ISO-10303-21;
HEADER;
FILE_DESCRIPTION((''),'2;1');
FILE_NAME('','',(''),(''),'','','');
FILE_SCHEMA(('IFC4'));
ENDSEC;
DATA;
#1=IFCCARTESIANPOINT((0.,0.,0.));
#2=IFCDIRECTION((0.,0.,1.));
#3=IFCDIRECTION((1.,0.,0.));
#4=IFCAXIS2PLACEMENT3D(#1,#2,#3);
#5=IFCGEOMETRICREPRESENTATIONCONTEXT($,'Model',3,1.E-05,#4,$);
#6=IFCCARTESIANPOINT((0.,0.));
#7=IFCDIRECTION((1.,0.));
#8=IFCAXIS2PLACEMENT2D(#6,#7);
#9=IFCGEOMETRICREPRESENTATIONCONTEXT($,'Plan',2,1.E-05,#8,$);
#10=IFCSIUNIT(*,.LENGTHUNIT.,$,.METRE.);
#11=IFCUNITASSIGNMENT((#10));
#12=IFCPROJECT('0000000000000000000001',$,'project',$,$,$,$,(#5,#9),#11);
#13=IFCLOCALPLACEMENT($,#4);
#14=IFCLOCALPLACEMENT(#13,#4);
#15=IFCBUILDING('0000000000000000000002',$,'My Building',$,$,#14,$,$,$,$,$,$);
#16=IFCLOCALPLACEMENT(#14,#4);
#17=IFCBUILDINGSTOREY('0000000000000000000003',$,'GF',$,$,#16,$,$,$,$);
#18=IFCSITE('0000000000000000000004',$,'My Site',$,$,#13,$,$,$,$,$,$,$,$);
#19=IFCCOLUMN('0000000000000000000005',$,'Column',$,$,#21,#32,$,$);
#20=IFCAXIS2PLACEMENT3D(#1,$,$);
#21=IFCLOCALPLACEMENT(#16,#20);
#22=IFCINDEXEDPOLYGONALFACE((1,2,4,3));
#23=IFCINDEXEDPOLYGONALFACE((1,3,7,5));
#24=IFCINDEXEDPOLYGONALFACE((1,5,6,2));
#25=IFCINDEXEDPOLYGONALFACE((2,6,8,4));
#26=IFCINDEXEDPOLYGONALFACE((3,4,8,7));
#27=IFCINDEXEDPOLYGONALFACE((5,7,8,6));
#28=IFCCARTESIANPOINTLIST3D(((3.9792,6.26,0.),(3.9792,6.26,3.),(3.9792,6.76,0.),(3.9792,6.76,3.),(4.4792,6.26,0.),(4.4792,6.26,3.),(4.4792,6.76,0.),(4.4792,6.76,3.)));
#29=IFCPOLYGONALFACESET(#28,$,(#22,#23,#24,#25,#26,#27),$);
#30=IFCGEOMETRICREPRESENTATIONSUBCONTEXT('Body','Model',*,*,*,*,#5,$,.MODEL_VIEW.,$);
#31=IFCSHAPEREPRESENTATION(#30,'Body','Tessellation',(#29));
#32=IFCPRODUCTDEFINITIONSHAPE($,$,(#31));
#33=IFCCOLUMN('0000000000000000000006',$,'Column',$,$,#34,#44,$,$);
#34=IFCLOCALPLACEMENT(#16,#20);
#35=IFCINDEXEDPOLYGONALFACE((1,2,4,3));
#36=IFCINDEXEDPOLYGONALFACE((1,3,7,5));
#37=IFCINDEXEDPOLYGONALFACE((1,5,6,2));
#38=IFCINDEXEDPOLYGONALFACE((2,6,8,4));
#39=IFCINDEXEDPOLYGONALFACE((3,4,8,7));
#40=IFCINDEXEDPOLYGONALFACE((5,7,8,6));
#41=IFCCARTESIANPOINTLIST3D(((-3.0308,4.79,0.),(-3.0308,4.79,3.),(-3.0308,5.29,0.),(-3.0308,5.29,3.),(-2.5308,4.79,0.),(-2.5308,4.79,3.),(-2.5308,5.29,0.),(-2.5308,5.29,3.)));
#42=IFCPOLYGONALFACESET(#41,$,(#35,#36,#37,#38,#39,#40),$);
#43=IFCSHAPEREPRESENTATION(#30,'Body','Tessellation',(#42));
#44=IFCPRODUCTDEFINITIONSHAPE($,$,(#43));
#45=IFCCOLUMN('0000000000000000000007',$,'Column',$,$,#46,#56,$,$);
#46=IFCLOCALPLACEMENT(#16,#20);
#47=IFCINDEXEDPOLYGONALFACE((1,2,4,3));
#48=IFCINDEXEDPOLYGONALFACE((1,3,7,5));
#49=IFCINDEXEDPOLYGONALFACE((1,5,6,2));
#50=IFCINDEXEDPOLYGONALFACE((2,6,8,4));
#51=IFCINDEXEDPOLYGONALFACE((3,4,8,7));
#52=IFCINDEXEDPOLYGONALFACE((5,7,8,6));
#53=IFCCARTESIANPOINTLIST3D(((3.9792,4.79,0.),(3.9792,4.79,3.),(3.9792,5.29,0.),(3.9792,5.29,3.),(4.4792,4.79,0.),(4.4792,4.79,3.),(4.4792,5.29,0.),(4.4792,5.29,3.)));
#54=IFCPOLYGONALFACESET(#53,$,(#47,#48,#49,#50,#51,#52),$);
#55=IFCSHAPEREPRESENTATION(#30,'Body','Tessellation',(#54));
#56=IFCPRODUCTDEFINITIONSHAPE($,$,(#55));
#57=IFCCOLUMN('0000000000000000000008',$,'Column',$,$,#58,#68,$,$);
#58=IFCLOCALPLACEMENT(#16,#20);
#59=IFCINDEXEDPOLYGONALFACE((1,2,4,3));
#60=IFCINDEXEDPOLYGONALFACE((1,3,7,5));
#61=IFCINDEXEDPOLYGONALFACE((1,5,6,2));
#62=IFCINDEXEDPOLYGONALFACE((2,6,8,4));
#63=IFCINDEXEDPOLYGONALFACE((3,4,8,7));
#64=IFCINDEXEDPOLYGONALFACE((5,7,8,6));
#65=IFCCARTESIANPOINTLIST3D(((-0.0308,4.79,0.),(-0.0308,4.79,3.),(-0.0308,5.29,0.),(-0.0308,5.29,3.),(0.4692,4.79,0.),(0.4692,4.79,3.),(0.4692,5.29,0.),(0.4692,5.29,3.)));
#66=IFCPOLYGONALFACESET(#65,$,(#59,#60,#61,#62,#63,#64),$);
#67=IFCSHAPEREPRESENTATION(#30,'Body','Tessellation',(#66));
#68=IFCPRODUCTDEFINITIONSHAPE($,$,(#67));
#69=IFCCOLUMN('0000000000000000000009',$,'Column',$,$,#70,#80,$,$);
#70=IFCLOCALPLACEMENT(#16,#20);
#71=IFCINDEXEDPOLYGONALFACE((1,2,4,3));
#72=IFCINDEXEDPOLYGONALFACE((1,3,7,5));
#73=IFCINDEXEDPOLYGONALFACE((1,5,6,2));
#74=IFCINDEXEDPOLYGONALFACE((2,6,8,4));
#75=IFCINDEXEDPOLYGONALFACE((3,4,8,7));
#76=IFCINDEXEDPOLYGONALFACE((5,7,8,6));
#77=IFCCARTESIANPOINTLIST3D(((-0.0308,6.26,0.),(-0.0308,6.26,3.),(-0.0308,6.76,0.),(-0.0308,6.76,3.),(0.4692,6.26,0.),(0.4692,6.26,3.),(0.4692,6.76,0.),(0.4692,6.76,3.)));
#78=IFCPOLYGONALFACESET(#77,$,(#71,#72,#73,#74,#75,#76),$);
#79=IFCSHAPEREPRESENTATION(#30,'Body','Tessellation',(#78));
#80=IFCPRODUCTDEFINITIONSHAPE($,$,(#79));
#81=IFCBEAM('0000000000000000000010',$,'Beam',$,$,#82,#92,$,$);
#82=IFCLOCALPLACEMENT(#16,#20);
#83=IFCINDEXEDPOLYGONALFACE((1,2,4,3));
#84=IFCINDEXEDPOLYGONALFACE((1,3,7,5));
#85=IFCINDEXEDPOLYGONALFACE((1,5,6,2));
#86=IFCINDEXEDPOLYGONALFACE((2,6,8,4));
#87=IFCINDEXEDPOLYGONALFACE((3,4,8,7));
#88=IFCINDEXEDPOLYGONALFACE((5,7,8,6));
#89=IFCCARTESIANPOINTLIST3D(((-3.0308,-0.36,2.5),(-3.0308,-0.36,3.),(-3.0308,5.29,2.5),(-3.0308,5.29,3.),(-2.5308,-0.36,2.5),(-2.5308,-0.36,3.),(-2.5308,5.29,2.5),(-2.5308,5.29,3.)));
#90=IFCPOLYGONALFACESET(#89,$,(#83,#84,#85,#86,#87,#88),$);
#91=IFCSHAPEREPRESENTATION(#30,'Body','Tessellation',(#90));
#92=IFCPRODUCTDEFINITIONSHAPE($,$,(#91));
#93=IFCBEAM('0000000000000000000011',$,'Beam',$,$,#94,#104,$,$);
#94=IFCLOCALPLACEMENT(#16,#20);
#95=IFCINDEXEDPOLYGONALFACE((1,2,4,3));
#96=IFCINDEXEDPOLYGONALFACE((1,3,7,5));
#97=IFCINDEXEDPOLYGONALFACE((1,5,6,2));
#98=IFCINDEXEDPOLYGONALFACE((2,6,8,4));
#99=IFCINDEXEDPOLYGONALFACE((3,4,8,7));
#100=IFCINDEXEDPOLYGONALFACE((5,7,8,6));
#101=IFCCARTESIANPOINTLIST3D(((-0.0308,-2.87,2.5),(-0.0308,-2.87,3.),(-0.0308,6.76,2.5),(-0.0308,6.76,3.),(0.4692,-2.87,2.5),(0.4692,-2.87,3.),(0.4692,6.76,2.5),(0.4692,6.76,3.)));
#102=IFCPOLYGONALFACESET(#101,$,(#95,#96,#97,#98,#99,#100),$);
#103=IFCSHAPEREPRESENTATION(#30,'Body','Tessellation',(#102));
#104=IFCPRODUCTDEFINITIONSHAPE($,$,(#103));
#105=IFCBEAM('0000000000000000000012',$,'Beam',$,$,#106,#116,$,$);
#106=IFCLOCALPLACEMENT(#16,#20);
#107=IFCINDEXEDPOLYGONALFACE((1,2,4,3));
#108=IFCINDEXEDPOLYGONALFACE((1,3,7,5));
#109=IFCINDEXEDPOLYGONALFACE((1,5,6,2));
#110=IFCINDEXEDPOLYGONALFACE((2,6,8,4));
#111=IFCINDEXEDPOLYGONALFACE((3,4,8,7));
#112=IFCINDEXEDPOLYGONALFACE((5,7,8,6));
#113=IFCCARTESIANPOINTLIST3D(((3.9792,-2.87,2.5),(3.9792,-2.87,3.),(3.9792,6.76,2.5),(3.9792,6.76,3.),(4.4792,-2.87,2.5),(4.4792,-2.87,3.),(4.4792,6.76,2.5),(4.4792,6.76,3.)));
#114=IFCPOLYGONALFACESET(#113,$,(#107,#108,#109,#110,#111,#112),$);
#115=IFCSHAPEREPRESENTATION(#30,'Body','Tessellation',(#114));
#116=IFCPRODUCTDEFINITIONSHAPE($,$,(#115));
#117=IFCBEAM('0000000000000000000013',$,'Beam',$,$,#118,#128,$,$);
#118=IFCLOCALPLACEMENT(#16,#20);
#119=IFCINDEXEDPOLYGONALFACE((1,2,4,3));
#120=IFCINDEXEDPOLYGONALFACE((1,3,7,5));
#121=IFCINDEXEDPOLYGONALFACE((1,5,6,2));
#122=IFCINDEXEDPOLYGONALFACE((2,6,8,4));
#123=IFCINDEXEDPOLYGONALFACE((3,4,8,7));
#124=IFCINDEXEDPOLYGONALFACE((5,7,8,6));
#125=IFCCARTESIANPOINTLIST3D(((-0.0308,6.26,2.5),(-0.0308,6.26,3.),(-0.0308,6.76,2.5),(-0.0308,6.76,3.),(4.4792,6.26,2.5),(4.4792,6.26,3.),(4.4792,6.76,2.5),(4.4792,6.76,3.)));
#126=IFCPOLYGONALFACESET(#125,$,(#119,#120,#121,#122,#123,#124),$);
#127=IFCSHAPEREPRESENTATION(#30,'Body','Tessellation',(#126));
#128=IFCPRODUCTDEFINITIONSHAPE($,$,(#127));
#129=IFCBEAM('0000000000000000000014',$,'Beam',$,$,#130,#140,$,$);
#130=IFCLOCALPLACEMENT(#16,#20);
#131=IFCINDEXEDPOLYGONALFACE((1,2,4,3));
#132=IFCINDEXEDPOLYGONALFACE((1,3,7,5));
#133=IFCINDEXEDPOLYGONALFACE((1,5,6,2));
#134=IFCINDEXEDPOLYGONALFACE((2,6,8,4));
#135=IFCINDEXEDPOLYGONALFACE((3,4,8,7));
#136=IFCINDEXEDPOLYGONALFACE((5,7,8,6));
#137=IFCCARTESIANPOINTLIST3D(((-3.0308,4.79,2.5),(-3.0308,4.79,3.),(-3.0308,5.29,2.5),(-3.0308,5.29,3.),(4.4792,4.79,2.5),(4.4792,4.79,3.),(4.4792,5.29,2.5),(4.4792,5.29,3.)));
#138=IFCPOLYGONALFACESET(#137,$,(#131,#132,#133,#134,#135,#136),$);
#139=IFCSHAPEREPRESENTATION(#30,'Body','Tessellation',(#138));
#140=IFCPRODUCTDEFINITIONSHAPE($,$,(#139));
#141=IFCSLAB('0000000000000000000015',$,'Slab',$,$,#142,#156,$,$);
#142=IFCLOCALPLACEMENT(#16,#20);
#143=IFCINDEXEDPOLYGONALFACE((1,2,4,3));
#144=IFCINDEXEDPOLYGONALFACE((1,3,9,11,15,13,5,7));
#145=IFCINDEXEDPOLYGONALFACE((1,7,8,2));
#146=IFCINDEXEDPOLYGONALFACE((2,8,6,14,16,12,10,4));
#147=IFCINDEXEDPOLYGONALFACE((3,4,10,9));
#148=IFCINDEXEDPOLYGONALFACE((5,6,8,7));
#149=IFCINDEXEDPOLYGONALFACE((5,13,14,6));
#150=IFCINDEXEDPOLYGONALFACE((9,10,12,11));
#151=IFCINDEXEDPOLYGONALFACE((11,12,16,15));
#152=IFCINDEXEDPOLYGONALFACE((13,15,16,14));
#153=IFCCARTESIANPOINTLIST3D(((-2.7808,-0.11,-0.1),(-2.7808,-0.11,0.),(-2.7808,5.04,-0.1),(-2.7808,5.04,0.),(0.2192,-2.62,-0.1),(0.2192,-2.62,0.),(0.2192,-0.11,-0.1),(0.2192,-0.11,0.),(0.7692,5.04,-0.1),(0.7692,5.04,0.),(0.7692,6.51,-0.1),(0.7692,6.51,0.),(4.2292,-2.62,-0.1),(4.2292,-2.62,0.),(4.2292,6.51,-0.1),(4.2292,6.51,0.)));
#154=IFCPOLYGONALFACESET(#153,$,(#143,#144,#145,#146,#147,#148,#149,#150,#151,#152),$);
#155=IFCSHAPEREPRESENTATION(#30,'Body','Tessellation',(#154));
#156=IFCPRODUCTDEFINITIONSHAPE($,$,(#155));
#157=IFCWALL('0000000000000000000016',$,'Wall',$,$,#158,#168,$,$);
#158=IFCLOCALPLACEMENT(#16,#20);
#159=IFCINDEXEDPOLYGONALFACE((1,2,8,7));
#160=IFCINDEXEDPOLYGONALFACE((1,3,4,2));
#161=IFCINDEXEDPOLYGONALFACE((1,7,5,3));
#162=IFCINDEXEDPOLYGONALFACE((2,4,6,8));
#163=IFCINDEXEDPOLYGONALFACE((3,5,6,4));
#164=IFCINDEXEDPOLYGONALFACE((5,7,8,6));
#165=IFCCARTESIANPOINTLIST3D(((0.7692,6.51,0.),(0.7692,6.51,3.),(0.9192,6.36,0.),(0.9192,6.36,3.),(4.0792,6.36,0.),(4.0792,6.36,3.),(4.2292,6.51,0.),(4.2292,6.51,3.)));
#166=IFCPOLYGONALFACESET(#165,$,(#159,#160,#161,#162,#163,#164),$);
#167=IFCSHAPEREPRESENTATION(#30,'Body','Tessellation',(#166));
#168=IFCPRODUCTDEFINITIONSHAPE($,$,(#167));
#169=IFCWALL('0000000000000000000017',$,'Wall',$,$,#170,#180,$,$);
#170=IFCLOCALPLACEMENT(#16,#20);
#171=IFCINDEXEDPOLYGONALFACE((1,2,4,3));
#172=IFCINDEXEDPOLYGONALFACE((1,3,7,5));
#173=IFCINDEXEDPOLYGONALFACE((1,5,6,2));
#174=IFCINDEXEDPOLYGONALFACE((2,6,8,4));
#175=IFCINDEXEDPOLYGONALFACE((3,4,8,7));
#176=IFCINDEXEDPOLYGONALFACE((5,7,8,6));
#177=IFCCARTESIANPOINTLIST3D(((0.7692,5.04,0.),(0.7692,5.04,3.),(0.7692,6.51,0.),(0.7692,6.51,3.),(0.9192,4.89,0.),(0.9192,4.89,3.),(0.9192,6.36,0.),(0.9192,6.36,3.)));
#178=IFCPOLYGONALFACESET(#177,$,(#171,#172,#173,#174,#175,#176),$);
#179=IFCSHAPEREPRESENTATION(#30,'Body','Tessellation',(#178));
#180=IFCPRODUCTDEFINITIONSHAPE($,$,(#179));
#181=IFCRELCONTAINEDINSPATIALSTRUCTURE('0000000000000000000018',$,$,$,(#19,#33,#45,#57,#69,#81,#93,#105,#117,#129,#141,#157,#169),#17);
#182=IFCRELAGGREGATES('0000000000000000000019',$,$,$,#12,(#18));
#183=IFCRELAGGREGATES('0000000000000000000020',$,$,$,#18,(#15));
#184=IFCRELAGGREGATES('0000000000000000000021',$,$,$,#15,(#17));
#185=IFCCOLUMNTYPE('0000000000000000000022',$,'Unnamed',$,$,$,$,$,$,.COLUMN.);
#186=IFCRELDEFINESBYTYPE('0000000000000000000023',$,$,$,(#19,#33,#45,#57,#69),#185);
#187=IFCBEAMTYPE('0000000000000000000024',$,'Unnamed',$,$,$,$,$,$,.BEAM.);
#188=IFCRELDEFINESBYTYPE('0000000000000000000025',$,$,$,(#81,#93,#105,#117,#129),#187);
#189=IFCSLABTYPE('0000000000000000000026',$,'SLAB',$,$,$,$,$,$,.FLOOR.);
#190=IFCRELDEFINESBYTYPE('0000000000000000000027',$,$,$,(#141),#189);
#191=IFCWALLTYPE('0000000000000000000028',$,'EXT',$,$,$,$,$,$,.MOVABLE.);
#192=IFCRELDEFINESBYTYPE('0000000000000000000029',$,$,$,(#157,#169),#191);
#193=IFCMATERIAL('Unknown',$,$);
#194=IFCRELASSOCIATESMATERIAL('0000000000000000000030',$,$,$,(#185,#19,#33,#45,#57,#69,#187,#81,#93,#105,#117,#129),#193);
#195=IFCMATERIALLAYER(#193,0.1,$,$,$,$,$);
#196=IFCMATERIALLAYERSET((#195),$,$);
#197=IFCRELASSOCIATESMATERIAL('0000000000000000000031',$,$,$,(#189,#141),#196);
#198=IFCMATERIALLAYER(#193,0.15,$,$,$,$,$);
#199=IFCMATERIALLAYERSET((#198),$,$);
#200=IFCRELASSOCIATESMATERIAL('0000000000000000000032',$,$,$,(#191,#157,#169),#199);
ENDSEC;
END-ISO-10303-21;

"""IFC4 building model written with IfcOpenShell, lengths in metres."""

from ifc_helpers import new_model, si_unit, frame, origin_with_axes, origin_2d_with_axis, place, context, subcontext, project, spatial, line, indexed_curve, rectangle, outline, extrude, material, layer, layer_set, layer_usage, material_profile, profile_set, profile_usage, type_object, element, save


model = new_model("IFC4")

# Units and contexts
model_context = context("Model", 3, precision=1e-05, world=origin_with_axes())
plan_context = context("Plan", 2, precision=1e-05, world=origin_2d_with_axis())
body_context_1 = subcontext(model_context, "Body", "Model", "MODEL_VIEW")
ifc_project = project(units=[si_unit("LENGTHUNIT", "METRE")], contexts=[model_context, plan_context])

# Site, building, storey
site_placement = place(None, origin_with_axes())
site = spatial("IfcSite", under=ifc_project, at=site_placement, Name="My Site")
building_placement = place(site_placement, origin_with_axes())
building = spatial("IfcBuilding", under=site, at=building_placement, Name="My Building")
storey_placement = place(building_placement, origin_with_axes())
storey = spatial("IfcBuildingStorey", under=building, at=storey_placement, Name="GF")

# Columns
ifc_material = material(Name="Unknown")
ifc_material_profile_1 = material_profile(ifc_material, rectangle(XDim=0.5, YDim=0.5))
ifc_profile_set_1 = profile_set([ifc_material_profile_1])
ifc_profile_usage_1 = profile_usage(ifc_profile_set_1, cardinal=5)
column_type = type_object("IfcColumnType", Name="Unnamed", PredefinedType="COLUMN", material=ifc_profile_set_1)
column_1_placement = place(storey_placement, frame((4.2292, 6.51, 0.0), z_axis=(0.0, 0.0, 1.0), x_axis=(1.0, 0.0, 0.0)))
element("IfcColumn", 1, at=column_1_placement, inside=storey, type_object=column_type, material=ifc_profile_usage_1, Name="Column", context=body_context_1, shape_type="SweptSolid", body=[
    extrude(rectangle(XDim=0.5, YDim=0.5), origin_with_axes(), (0.0, 0.0, 1.0), 3.0),
])
ifc_profile_usage_2 = profile_usage(ifc_profile_set_1, cardinal=5)
column_2_placement = place(storey_placement, frame((-2.7808, 5.04, 0.0), z_axis=(0.0, 0.0, 1.0), x_axis=(1.0, 0.0, 0.0)))
element("IfcColumn", 2, at=column_2_placement, inside=storey, type_object=column_type, material=ifc_profile_usage_2, Name="Column", context=body_context_1, shape_type="SweptSolid", body=[
    extrude(rectangle(XDim=0.5, YDim=0.5), origin_with_axes(), (0.0, 0.0, 1.0), 3.0),
])
ifc_profile_usage_3 = profile_usage(ifc_profile_set_1, cardinal=5)
column_3_placement = place(storey_placement, frame((4.2292, 5.04, 0.0), z_axis=(0.0, 0.0, 1.0), x_axis=(1.0, 0.0, 0.0)))
element("IfcColumn", 3, at=column_3_placement, inside=storey, type_object=column_type, material=ifc_profile_usage_3, Name="Column", context=body_context_1, shape_type="SweptSolid", body=[
    extrude(rectangle(XDim=0.5, YDim=0.5), origin_with_axes(), (0.0, 0.0, 1.0), 3.0),
])
ifc_profile_usage_4 = profile_usage(ifc_profile_set_1, cardinal=5)
column_4_placement = place(storey_placement, frame((0.2192, 5.04, 0.0), z_axis=(0.0, 0.0, 1.0), x_axis=(1.0, 0.0, 0.0)))
element("IfcColumn", 4, at=column_4_placement, inside=storey, type_object=column_type, material=ifc_profile_usage_4, Name="Column", context=body_context_1, shape_type="SweptSolid", body=[
    extrude(rectangle(XDim=0.5, YDim=0.5), origin_with_axes(), (0.0, 0.0, 1.0), 3.0),
])
ifc_profile_usage_5 = profile_usage(ifc_profile_set_1, cardinal=5)
column_5_placement = place(storey_placement, frame((0.2192, 6.51, 0.0), z_axis=(0.0, 0.0, 1.0), x_axis=(1.0, 0.0, 0.0)))
element("IfcColumn", 5, at=column_5_placement, inside=storey, type_object=column_type, material=ifc_profile_usage_5, Name="Column", context=body_context_1, shape_type="SweptSolid", body=[
    extrude(rectangle(XDim=0.5, YDim=0.5), origin_with_axes(), (0.0, 0.0, 1.0), 3.0),
])

# Beams
ifc_material_profile_2 = material_profile(ifc_material, rectangle(XDim=0.5, YDim=0.5))
ifc_profile_set_2 = profile_set([ifc_material_profile_2])
ifc_profile_usage_6 = profile_usage(ifc_profile_set_2, cardinal=7)
beam_type = type_object("IfcBeamType", Name="Unnamed", PredefinedType="BEAM", material=ifc_profile_set_2)
beam_1_placement = place(storey_placement, frame((-2.5308, 5.29, 3.0), z_axis=(0.0, -1.0, 0.0), x_axis=(1.0, 0.0, 0.0)))
element("IfcBeam", 6, at=beam_1_placement, inside=storey, type_object=beam_type, material=ifc_profile_usage_6, Name="Beam", context=body_context_1, shape_type="SweptSolid", body=[
    extrude(rectangle(XDim=0.5, YDim=0.5), frame((-0.25, -0.25, 0.0), z_axis=(0.0, 0.0, 1.0), x_axis=(1.0, 0.0, 0.0)), (0.0, 0.0, 1.0), 5.65),
])
ifc_profile_usage_7 = profile_usage(ifc_profile_set_2, cardinal=7)
beam_2_placement = place(storey_placement, frame((0.4692, 6.76, 3.0), z_axis=(0.0, -1.0, 0.0), x_axis=(1.0, 0.0, 0.0)))
element("IfcBeam", 7, at=beam_2_placement, inside=storey, type_object=beam_type, material=ifc_profile_usage_7, Name="Beam", context=body_context_1, shape_type="SweptSolid", body=[
    extrude(rectangle(XDim=0.5, YDim=0.5), frame((-0.25, -0.25, 0.0), z_axis=(0.0, 0.0, 1.0), x_axis=(1.0, 0.0, 0.0)), (0.0, 0.0, 1.0), 9.63),
])
ifc_profile_usage_8 = profile_usage(ifc_profile_set_2, cardinal=7)
beam_3_placement = place(storey_placement, frame((4.4792, 6.76, 3.0), z_axis=(0.0, -1.0, 0.0), x_axis=(1.0, 0.0, 0.0)))
element("IfcBeam", 8, at=beam_3_placement, inside=storey, type_object=beam_type, material=ifc_profile_usage_8, Name="Beam", context=body_context_1, shape_type="SweptSolid", body=[
    extrude(rectangle(XDim=0.5, YDim=0.5), frame((-0.25, -0.25, 0.0), z_axis=(0.0, 0.0, 1.0), x_axis=(1.0, 0.0, 0.0)), (0.0, 0.0, 1.0), 9.63),
])
ifc_profile_usage_9 = profile_usage(ifc_profile_set_2, cardinal=7)
beam_4_placement = place(storey_placement, frame((4.4792, 6.26, 3.0), z_axis=(-1.0, 0.0, 0.0), x_axis=(0.0, -1.0, 0.0)))
element("IfcBeam", 9, at=beam_4_placement, inside=storey, type_object=beam_type, material=ifc_profile_usage_9, Name="Beam", context=body_context_1, shape_type="SweptSolid", body=[
    extrude(rectangle(XDim=0.5, YDim=0.5), frame((-0.25, -0.25, 0.0), z_axis=(0.0, 0.0, 1.0), x_axis=(1.0, 0.0, 0.0)), (0.0, 0.0, 1.0), 4.51),
])
ifc_profile_usage_10 = profile_usage(ifc_profile_set_2, cardinal=7)
beam_5_placement = place(storey_placement, frame((4.4792, 4.79, 3.0), z_axis=(-1.0, 0.0, 0.0), x_axis=(0.0, -1.0, 0.0)))
element("IfcBeam", 10, at=beam_5_placement, inside=storey, type_object=beam_type, material=ifc_profile_usage_10, Name="Beam", context=body_context_1, shape_type="SweptSolid", body=[
    extrude(rectangle(XDim=0.5, YDim=0.5), frame((-0.25, -0.25, 0.0), z_axis=(0.0, 0.0, 1.0), x_axis=(1.0, 0.0, 0.0)), (0.0, 0.0, 1.0), 7.51),
])

# Slab
ifc_layer_1 = layer(ifc_material, 0.1)
ifc_layer_set_1 = layer_set([ifc_layer_1])
ifc_layer_usage_1 = layer_usage(ifc_layer_set_1, "AXIS3", "POSITIVE", -0.1)
slab_type = type_object("IfcSlabType", Name="SLAB", PredefinedType="FLOOR", material=ifc_layer_set_1)
slab_placement = place(storey_placement, frame((0.7692, 6.51, 0.0), z_axis=(0.0, 0.0, 1.0), x_axis=(1.0, 0.0, 0.0)))
element("IfcSlab", 11, at=slab_placement, inside=storey, type_object=slab_type, material=ifc_layer_usage_1, Name="Slab", context=body_context_1, shape_type="SweptSolid", body=[
    extrude(outline(indexed_curve([(0.0, 0.0), (3.46, 0.0), (3.46, -9.13), (-0.55, -9.13), (-0.55, -6.62), (-3.55, -6.62), (-3.55, -1.47), (0.0, -1.47), (0.0, 0.0)])), frame((0.0, 0.0, -0.1), z_axis=(0.0, 0.0, 1.0), x_axis=(1.0, 0.0, 0.0)), (0.0, 0.0, 1.0), 0.1),
])

# Walls
ifc_layer_2 = layer(ifc_material, 0.15)
ifc_layer_set_2 = layer_set([ifc_layer_2])
ifc_layer_usage_2 = layer_usage(ifc_layer_set_2, "AXIS2", "POSITIVE", 0.0)
wall_type_1 = type_object("IfcWallType", Name="EXT", PredefinedType="MOVABLE", material=ifc_layer_set_2)
wall_1_placement = place(storey_placement, frame((4.2292, 6.51, 0.0), z_axis=(0.0, 0.0, 1.0), x_axis=(-1.0, 0.0, 0.0)))
element("IfcWall", 12, at=wall_1_placement, inside=storey, type_object=wall_type_1, material=ifc_layer_usage_2, Name="Wall", context=body_context_1, shape_type="SweptSolid", body=[
    extrude(outline(indexed_curve([(0.0, 0.0), (0.15, 0.15), (3.31, 0.15), (3.46, 0.0)], segments=[line(1, 2, 3, 4, 1)])), origin_with_axes(), (0.0, 0.0, 1.0), 3.0),
])
ifc_layer_usage_3 = layer_usage(ifc_layer_set_2, "AXIS2", "POSITIVE", 0.0)
wall_2_placement = place(storey_placement, frame((0.7692, 6.51, 0.0), z_axis=(0.0, 0.0, 1.0), x_axis=(0.0, -1.0, 0.0)))
element("IfcWall", 13, at=wall_2_placement, inside=storey, type_object=wall_type_1, material=ifc_layer_usage_3, Name="Wall", context=body_context_1, shape_type="SweptSolid", body=[
    extrude(outline(indexed_curve([(0.0, 0.0), (0.15, 0.15), (1.62, 0.15), (1.47, 0.0)], segments=[line(1, 2, 3, 4, 1)])), origin_with_axes(), (0.0, 0.0, 1.0), 3.0),
])

save(model, "model.ifc")
